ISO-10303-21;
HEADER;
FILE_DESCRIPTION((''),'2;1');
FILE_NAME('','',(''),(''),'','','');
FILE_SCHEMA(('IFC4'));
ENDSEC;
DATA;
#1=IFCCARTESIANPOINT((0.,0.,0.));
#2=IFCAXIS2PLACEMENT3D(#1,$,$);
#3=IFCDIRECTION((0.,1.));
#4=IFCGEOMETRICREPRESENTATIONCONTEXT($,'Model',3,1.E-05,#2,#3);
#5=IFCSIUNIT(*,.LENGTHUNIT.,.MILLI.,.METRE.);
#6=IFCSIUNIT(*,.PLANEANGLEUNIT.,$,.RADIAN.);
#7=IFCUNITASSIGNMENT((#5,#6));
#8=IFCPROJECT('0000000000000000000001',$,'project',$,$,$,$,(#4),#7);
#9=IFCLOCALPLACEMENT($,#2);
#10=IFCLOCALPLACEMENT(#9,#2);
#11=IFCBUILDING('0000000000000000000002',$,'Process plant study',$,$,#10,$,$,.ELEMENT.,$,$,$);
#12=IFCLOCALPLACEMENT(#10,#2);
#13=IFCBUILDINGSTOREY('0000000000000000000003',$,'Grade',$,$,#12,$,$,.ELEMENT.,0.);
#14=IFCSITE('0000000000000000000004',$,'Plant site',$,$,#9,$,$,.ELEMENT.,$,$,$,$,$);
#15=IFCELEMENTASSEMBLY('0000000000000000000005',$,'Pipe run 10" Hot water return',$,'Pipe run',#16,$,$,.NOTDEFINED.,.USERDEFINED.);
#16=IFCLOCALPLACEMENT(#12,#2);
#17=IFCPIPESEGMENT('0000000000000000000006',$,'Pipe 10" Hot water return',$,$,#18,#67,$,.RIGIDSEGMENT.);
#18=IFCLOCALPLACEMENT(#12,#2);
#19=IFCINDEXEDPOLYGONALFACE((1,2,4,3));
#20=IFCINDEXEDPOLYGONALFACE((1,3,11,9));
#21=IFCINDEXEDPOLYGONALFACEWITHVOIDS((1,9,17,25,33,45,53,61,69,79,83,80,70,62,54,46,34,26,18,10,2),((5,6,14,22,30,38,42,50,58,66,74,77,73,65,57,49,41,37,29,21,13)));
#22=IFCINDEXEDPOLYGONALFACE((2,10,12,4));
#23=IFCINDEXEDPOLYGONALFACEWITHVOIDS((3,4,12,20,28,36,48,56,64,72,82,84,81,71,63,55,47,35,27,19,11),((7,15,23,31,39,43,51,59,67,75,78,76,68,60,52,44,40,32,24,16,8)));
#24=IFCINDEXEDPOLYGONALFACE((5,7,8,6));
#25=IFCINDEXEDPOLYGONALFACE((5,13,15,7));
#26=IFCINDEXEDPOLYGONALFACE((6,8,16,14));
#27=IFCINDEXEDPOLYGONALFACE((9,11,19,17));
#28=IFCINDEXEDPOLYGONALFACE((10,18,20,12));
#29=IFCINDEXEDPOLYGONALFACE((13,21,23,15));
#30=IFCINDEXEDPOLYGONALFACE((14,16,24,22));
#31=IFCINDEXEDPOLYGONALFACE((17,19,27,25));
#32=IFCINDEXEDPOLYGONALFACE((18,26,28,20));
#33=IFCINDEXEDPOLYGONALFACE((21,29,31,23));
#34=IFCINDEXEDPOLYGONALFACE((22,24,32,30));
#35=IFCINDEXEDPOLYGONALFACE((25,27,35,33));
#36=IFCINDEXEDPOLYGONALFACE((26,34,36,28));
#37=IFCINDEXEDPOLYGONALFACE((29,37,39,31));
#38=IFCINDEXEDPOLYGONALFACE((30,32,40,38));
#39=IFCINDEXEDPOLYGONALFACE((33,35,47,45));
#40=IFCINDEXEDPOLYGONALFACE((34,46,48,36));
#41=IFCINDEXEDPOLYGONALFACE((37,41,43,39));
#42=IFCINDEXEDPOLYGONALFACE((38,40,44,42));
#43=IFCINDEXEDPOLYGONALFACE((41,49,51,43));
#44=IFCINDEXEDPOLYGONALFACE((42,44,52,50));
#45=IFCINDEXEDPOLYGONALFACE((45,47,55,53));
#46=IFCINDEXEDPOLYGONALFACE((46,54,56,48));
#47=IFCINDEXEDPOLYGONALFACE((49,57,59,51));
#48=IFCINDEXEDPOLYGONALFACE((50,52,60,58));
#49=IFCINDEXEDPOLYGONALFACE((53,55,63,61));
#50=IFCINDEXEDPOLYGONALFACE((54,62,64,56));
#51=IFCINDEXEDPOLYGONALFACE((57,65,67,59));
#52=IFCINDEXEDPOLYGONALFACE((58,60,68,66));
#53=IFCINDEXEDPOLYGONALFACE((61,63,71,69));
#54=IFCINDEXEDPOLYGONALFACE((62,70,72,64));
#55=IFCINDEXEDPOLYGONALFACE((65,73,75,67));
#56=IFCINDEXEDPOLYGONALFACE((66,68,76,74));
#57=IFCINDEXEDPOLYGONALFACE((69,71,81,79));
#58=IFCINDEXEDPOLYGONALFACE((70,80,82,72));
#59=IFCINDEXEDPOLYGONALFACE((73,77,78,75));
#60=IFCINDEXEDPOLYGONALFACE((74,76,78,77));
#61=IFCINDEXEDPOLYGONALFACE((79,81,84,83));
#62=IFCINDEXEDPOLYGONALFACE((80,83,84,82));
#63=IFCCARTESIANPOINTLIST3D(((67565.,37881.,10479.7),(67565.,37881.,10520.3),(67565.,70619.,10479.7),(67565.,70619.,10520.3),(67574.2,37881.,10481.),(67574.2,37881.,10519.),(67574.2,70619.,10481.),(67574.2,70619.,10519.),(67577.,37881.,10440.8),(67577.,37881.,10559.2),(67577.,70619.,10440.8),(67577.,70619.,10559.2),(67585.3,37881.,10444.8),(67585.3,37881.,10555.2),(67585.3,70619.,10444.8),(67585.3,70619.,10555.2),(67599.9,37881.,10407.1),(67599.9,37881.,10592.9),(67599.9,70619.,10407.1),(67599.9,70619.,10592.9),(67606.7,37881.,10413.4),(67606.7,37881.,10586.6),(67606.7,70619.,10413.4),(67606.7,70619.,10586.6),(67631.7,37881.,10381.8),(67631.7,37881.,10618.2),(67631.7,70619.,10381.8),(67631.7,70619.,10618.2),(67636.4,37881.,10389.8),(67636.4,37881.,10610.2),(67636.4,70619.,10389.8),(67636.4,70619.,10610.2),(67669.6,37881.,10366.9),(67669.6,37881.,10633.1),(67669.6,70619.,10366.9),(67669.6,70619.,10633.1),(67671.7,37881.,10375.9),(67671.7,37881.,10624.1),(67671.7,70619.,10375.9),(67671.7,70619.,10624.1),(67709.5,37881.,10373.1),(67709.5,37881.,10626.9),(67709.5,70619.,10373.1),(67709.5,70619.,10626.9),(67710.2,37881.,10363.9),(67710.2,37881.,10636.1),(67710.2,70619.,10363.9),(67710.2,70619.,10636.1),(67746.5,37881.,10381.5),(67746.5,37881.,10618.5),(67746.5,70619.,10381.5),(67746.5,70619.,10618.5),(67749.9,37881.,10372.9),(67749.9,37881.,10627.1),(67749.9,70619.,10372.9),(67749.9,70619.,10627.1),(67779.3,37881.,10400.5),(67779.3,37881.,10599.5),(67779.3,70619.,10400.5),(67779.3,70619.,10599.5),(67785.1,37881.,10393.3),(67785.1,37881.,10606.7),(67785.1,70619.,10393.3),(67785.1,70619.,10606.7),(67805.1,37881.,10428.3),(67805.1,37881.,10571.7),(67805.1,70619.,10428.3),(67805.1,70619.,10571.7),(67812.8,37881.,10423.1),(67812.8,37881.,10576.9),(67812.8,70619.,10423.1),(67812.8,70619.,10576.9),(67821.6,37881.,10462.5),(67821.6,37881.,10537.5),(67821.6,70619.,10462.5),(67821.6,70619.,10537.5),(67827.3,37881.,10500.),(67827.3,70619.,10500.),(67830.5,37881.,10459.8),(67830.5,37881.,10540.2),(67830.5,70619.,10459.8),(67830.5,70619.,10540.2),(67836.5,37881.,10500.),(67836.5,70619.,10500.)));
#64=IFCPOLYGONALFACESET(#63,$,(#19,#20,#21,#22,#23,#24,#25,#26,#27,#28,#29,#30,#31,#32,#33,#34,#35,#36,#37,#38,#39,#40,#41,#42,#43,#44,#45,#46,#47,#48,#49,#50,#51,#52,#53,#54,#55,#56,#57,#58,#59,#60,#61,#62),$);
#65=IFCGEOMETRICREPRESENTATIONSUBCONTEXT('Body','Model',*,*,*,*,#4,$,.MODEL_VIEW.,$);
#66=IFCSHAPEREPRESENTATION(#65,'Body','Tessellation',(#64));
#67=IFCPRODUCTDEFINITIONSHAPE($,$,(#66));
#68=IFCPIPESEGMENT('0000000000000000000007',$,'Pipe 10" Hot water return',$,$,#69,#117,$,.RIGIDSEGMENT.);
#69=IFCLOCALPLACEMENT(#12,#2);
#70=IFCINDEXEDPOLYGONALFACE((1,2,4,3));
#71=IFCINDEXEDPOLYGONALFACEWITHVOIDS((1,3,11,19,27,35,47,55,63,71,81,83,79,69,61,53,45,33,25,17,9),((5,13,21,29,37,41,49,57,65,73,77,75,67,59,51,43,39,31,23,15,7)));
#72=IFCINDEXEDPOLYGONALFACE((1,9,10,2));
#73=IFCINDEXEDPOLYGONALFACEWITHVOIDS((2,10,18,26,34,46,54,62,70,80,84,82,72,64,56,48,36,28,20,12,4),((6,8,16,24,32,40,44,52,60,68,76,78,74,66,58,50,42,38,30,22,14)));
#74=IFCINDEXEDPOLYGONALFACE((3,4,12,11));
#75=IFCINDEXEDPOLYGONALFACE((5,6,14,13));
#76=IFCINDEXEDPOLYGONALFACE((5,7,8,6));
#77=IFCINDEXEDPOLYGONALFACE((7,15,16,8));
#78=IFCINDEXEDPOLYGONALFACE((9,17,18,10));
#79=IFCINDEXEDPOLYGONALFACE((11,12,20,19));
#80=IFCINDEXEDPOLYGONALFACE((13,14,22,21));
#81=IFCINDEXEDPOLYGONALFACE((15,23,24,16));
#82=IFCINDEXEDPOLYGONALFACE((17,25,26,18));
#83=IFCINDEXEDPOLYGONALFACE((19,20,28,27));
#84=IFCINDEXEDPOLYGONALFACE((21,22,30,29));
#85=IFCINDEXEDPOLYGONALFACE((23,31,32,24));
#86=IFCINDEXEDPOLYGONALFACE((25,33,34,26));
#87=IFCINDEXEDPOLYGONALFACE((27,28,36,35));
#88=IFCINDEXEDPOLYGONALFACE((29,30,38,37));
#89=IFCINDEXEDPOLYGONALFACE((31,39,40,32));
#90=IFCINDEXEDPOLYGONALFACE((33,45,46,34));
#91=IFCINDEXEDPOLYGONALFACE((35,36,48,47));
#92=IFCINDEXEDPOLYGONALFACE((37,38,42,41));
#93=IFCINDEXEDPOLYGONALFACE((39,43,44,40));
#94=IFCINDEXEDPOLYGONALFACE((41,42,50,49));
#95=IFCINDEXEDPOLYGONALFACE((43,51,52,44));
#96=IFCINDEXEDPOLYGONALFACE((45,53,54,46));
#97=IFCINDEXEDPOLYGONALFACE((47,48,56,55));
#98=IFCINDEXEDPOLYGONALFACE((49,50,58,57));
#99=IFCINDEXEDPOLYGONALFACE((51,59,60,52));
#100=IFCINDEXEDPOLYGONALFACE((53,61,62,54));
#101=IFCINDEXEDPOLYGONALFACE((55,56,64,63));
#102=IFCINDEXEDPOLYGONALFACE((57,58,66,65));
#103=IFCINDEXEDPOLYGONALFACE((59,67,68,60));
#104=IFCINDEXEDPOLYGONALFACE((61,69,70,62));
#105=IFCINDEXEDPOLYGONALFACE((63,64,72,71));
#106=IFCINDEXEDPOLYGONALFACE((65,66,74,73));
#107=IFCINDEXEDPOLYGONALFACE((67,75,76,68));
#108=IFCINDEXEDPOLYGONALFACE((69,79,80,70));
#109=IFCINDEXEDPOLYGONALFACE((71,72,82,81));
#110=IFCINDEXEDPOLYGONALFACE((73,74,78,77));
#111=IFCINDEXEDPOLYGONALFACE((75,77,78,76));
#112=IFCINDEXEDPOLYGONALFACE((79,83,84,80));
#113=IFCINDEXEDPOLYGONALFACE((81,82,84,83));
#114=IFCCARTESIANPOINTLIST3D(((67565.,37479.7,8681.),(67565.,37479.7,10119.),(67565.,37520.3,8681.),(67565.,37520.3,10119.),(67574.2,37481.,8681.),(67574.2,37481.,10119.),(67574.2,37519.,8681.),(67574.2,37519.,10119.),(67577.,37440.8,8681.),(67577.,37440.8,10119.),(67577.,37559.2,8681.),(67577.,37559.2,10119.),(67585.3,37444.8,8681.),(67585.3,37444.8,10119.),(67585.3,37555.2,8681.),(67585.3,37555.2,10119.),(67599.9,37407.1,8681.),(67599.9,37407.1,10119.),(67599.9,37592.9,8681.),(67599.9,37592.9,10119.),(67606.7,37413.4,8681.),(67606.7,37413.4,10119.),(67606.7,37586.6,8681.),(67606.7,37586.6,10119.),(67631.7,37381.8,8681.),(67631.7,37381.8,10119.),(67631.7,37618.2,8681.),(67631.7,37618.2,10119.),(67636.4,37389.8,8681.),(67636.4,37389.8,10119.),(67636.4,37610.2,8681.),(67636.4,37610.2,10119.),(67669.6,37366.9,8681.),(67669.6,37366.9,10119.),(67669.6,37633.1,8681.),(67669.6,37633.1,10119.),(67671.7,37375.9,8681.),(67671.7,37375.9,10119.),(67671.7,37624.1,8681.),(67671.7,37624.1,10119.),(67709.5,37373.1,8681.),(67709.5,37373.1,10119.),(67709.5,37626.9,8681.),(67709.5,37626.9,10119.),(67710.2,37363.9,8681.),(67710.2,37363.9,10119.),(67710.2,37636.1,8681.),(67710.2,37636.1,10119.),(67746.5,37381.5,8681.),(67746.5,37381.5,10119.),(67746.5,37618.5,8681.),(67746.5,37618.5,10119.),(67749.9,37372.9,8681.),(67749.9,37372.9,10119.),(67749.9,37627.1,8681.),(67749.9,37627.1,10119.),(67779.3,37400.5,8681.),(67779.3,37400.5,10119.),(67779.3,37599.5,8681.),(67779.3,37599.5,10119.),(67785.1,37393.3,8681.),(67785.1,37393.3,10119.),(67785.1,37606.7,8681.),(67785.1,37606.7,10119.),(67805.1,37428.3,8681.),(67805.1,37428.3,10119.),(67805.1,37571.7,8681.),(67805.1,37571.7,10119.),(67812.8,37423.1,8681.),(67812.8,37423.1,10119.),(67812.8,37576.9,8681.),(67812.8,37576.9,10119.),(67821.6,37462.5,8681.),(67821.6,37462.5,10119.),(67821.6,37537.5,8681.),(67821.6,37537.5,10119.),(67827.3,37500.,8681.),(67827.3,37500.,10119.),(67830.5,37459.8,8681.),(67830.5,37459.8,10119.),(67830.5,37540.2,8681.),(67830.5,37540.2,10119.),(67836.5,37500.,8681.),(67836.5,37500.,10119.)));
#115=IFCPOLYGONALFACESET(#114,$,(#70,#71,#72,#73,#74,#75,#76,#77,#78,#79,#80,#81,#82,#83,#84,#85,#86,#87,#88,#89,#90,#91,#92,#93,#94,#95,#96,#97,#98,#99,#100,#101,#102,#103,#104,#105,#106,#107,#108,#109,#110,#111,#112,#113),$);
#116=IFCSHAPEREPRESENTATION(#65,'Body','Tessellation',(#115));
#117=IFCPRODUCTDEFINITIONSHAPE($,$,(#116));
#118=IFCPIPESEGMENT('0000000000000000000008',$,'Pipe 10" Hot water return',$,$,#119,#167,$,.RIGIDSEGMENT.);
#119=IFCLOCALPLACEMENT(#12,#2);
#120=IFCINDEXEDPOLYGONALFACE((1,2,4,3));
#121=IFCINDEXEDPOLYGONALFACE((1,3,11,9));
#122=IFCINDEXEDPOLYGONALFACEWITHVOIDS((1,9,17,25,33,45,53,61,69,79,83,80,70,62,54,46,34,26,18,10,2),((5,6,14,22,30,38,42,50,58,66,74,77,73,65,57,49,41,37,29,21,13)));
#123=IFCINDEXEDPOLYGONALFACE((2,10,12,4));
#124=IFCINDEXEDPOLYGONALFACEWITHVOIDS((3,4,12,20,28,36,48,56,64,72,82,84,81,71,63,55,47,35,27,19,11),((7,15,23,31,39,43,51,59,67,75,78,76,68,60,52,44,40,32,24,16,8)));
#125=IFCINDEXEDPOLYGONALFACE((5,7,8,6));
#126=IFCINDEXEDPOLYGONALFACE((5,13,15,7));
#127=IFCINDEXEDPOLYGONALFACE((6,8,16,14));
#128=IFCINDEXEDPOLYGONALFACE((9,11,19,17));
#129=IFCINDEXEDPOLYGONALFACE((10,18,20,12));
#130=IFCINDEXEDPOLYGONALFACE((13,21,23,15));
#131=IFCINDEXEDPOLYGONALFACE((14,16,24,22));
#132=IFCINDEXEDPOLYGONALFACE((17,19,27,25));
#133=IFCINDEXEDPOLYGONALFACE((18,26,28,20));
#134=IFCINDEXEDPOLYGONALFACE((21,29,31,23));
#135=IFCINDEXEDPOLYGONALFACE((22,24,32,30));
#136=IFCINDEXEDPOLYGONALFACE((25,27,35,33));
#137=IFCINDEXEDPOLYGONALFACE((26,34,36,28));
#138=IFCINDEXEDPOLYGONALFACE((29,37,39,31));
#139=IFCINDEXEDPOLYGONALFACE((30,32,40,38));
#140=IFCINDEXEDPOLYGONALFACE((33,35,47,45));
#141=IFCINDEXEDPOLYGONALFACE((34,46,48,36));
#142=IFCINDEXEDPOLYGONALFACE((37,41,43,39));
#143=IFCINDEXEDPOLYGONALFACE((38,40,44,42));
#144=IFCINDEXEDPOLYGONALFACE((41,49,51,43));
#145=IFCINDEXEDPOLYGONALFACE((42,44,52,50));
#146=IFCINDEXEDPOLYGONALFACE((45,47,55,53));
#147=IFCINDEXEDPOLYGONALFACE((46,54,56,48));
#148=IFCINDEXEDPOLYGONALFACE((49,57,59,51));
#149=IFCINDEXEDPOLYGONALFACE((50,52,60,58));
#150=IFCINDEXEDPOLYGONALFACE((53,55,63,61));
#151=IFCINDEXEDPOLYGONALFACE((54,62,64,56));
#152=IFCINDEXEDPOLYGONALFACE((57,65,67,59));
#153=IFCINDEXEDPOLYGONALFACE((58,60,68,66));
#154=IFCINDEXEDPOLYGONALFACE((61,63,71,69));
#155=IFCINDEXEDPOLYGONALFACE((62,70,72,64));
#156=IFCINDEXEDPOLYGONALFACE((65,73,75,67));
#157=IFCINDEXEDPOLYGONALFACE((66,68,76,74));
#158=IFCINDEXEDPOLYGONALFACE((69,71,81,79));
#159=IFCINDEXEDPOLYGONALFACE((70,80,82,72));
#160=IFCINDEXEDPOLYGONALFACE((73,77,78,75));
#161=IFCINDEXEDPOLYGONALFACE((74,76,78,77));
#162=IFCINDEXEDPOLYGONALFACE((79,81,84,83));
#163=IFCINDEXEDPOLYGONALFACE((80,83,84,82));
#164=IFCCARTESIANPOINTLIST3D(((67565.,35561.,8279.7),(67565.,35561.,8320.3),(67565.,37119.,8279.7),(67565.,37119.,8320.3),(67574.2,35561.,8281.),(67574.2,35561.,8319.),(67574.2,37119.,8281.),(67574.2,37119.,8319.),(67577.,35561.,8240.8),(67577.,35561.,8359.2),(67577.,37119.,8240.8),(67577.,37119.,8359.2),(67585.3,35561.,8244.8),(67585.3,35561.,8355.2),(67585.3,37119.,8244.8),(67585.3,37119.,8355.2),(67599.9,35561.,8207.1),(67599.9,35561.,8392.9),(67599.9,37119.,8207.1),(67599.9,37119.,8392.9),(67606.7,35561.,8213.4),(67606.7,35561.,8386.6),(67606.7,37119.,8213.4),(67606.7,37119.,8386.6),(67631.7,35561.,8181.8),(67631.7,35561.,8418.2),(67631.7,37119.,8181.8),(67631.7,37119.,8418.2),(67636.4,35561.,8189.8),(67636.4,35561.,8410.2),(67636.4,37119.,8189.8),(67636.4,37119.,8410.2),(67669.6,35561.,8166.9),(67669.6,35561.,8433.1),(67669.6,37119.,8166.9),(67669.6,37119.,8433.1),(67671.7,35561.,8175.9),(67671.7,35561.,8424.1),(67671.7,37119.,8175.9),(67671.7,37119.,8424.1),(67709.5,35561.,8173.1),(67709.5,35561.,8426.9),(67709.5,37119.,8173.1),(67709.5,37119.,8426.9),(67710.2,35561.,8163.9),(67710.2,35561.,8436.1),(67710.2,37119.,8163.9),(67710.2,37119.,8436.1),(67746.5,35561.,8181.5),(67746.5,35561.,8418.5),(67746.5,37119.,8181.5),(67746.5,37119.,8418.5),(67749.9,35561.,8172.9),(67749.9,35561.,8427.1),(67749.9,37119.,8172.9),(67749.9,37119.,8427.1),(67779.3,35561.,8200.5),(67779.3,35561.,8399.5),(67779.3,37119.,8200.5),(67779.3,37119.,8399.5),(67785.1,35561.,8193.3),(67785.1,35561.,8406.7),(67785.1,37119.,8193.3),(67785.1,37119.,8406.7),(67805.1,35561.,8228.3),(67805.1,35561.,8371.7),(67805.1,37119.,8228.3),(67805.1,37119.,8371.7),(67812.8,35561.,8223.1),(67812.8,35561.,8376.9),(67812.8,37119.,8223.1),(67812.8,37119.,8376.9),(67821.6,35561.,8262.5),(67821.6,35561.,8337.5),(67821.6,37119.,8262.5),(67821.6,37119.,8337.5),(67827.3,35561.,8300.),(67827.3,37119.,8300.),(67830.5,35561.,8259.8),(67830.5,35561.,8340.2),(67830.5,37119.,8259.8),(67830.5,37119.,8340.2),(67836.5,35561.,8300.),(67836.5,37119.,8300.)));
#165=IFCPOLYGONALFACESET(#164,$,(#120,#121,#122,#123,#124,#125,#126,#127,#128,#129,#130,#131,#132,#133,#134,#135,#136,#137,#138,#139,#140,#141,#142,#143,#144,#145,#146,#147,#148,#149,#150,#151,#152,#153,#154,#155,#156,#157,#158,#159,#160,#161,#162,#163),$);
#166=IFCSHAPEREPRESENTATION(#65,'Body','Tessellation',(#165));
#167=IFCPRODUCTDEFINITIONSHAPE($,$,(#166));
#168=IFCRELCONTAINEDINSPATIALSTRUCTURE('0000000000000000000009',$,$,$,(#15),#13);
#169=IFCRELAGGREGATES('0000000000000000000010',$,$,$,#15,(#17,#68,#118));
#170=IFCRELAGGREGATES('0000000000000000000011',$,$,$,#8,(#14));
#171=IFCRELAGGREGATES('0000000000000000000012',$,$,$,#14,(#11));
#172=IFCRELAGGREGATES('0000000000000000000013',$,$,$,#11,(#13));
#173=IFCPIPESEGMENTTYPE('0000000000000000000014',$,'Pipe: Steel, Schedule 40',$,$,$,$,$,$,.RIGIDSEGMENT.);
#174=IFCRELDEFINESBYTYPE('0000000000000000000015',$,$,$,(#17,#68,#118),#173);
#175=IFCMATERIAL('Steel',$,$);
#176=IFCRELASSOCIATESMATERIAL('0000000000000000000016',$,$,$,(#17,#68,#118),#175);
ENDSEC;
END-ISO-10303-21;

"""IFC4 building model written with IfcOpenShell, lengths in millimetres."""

from ifc_helpers import new_model, si_unit, direction, frame, origin, origin_with_axes, origin_2d, place, context, subcontext, project, spatial, hollow_circle, extrude, material, type_object, element, aggregate, save


model = new_model("IFC4")

# Units and contexts
model_context = context("Model", 3, precision=1e-05, world=origin(), true_north=direction((0.0, 1.0)))
body_context = subcontext(model_context, "Body", "Model", "MODEL_VIEW")
ifc_project = project(units=[si_unit("LENGTHUNIT", "METRE", prefix="MILLI"), si_unit("PLANEANGLEUNIT", "RADIAN")], contexts=[model_context])

# Site, building, storey
site_placement = place(None, origin())
site = spatial("IfcSite", under=ifc_project, at=site_placement, Name="Plant site", CompositionType="ELEMENT")
building_placement = place(site_placement, origin())
building = spatial("IfcBuilding", under=site, at=building_placement, Name="Process plant study", CompositionType="ELEMENT")
storey_placement = place(building_placement, origin())
storey = spatial("IfcBuildingStorey", under=building, at=storey_placement, Name="Grade", CompositionType="ELEMENT", Elevation=0.0)

# Shared definitions
ifc_material = material(Name="Steel")
pipe_segment_type = type_object("IfcPipeSegmentType", Name="Pipe: Steel, Schedule 40", PredefinedType="RIGIDSEGMENT")

# Element assembly, pipe segments
assembly_1_placement = place(storey_placement, origin_with_axes())
assembly_1 = element("IfcElementAssembly", 1, at=assembly_1_placement, inside=storey, Name="Pipe run 10\" Hot water return", ObjectType="Pipe run", AssemblyPlace="NOTDEFINED", PredefinedType="USERDEFINED")
pipe_segment_1_placement = place(storey_placement, origin_with_axes())
pipe_segment_1 = element("IfcPipeSegment", 2, at=pipe_segment_1_placement, type_object=pipe_segment_type, material=ifc_material, Name="Pipe 10\" Hot water return", PredefinedType="RIGIDSEGMENT", context=body_context, shape_type="SweptSolid", body=[
    extrude(hollow_circle(Radius=136.5, WallThickness=9.3, at=origin_2d()), frame((67700.0, 70619.0, 10500.0), z_axis=(0.0, -1.0, 0.0), x_axis=(1.0, 0.0, 0.0)), (0.0, 0.0, 1.0), 32738.0),
])
pipe_segment_2_placement = place(storey_placement, origin_with_axes())
pipe_segment_2 = element("IfcPipeSegment", 3, at=pipe_segment_2_placement, type_object=pipe_segment_type, material=ifc_material, Name="Pipe 10\" Hot water return", PredefinedType="RIGIDSEGMENT", context=body_context, shape_type="SweptSolid", body=[
    extrude(hollow_circle(Radius=136.5, WallThickness=9.3, at=origin_2d()), frame((67700.0, 37500.0, 10119.0), z_axis=(0.0, 0.0, -1.0), x_axis=(1.0, 0.0, 0.0)), (0.0, 0.0, 1.0), 1438.0),
])
pipe_segment_3_placement = place(storey_placement, origin_with_axes())
pipe_segment_3 = element("IfcPipeSegment", 4, at=pipe_segment_3_placement, type_object=pipe_segment_type, material=ifc_material, Name="Pipe 10\" Hot water return", PredefinedType="RIGIDSEGMENT", context=body_context, shape_type="SweptSolid", body=[
    extrude(hollow_circle(Radius=136.5, WallThickness=9.3, at=origin_2d()), frame((67700.0, 37119.0, 8300.0), z_axis=(0.0, -1.0, 0.0), x_axis=(1.0, 0.0, 0.0)), (0.0, 0.0, 1.0), 1558.0),
])

aggregate(assembly_1, [pipe_segment_1, pipe_segment_2, pipe_segment_3])

save(model, "model.ifc")
